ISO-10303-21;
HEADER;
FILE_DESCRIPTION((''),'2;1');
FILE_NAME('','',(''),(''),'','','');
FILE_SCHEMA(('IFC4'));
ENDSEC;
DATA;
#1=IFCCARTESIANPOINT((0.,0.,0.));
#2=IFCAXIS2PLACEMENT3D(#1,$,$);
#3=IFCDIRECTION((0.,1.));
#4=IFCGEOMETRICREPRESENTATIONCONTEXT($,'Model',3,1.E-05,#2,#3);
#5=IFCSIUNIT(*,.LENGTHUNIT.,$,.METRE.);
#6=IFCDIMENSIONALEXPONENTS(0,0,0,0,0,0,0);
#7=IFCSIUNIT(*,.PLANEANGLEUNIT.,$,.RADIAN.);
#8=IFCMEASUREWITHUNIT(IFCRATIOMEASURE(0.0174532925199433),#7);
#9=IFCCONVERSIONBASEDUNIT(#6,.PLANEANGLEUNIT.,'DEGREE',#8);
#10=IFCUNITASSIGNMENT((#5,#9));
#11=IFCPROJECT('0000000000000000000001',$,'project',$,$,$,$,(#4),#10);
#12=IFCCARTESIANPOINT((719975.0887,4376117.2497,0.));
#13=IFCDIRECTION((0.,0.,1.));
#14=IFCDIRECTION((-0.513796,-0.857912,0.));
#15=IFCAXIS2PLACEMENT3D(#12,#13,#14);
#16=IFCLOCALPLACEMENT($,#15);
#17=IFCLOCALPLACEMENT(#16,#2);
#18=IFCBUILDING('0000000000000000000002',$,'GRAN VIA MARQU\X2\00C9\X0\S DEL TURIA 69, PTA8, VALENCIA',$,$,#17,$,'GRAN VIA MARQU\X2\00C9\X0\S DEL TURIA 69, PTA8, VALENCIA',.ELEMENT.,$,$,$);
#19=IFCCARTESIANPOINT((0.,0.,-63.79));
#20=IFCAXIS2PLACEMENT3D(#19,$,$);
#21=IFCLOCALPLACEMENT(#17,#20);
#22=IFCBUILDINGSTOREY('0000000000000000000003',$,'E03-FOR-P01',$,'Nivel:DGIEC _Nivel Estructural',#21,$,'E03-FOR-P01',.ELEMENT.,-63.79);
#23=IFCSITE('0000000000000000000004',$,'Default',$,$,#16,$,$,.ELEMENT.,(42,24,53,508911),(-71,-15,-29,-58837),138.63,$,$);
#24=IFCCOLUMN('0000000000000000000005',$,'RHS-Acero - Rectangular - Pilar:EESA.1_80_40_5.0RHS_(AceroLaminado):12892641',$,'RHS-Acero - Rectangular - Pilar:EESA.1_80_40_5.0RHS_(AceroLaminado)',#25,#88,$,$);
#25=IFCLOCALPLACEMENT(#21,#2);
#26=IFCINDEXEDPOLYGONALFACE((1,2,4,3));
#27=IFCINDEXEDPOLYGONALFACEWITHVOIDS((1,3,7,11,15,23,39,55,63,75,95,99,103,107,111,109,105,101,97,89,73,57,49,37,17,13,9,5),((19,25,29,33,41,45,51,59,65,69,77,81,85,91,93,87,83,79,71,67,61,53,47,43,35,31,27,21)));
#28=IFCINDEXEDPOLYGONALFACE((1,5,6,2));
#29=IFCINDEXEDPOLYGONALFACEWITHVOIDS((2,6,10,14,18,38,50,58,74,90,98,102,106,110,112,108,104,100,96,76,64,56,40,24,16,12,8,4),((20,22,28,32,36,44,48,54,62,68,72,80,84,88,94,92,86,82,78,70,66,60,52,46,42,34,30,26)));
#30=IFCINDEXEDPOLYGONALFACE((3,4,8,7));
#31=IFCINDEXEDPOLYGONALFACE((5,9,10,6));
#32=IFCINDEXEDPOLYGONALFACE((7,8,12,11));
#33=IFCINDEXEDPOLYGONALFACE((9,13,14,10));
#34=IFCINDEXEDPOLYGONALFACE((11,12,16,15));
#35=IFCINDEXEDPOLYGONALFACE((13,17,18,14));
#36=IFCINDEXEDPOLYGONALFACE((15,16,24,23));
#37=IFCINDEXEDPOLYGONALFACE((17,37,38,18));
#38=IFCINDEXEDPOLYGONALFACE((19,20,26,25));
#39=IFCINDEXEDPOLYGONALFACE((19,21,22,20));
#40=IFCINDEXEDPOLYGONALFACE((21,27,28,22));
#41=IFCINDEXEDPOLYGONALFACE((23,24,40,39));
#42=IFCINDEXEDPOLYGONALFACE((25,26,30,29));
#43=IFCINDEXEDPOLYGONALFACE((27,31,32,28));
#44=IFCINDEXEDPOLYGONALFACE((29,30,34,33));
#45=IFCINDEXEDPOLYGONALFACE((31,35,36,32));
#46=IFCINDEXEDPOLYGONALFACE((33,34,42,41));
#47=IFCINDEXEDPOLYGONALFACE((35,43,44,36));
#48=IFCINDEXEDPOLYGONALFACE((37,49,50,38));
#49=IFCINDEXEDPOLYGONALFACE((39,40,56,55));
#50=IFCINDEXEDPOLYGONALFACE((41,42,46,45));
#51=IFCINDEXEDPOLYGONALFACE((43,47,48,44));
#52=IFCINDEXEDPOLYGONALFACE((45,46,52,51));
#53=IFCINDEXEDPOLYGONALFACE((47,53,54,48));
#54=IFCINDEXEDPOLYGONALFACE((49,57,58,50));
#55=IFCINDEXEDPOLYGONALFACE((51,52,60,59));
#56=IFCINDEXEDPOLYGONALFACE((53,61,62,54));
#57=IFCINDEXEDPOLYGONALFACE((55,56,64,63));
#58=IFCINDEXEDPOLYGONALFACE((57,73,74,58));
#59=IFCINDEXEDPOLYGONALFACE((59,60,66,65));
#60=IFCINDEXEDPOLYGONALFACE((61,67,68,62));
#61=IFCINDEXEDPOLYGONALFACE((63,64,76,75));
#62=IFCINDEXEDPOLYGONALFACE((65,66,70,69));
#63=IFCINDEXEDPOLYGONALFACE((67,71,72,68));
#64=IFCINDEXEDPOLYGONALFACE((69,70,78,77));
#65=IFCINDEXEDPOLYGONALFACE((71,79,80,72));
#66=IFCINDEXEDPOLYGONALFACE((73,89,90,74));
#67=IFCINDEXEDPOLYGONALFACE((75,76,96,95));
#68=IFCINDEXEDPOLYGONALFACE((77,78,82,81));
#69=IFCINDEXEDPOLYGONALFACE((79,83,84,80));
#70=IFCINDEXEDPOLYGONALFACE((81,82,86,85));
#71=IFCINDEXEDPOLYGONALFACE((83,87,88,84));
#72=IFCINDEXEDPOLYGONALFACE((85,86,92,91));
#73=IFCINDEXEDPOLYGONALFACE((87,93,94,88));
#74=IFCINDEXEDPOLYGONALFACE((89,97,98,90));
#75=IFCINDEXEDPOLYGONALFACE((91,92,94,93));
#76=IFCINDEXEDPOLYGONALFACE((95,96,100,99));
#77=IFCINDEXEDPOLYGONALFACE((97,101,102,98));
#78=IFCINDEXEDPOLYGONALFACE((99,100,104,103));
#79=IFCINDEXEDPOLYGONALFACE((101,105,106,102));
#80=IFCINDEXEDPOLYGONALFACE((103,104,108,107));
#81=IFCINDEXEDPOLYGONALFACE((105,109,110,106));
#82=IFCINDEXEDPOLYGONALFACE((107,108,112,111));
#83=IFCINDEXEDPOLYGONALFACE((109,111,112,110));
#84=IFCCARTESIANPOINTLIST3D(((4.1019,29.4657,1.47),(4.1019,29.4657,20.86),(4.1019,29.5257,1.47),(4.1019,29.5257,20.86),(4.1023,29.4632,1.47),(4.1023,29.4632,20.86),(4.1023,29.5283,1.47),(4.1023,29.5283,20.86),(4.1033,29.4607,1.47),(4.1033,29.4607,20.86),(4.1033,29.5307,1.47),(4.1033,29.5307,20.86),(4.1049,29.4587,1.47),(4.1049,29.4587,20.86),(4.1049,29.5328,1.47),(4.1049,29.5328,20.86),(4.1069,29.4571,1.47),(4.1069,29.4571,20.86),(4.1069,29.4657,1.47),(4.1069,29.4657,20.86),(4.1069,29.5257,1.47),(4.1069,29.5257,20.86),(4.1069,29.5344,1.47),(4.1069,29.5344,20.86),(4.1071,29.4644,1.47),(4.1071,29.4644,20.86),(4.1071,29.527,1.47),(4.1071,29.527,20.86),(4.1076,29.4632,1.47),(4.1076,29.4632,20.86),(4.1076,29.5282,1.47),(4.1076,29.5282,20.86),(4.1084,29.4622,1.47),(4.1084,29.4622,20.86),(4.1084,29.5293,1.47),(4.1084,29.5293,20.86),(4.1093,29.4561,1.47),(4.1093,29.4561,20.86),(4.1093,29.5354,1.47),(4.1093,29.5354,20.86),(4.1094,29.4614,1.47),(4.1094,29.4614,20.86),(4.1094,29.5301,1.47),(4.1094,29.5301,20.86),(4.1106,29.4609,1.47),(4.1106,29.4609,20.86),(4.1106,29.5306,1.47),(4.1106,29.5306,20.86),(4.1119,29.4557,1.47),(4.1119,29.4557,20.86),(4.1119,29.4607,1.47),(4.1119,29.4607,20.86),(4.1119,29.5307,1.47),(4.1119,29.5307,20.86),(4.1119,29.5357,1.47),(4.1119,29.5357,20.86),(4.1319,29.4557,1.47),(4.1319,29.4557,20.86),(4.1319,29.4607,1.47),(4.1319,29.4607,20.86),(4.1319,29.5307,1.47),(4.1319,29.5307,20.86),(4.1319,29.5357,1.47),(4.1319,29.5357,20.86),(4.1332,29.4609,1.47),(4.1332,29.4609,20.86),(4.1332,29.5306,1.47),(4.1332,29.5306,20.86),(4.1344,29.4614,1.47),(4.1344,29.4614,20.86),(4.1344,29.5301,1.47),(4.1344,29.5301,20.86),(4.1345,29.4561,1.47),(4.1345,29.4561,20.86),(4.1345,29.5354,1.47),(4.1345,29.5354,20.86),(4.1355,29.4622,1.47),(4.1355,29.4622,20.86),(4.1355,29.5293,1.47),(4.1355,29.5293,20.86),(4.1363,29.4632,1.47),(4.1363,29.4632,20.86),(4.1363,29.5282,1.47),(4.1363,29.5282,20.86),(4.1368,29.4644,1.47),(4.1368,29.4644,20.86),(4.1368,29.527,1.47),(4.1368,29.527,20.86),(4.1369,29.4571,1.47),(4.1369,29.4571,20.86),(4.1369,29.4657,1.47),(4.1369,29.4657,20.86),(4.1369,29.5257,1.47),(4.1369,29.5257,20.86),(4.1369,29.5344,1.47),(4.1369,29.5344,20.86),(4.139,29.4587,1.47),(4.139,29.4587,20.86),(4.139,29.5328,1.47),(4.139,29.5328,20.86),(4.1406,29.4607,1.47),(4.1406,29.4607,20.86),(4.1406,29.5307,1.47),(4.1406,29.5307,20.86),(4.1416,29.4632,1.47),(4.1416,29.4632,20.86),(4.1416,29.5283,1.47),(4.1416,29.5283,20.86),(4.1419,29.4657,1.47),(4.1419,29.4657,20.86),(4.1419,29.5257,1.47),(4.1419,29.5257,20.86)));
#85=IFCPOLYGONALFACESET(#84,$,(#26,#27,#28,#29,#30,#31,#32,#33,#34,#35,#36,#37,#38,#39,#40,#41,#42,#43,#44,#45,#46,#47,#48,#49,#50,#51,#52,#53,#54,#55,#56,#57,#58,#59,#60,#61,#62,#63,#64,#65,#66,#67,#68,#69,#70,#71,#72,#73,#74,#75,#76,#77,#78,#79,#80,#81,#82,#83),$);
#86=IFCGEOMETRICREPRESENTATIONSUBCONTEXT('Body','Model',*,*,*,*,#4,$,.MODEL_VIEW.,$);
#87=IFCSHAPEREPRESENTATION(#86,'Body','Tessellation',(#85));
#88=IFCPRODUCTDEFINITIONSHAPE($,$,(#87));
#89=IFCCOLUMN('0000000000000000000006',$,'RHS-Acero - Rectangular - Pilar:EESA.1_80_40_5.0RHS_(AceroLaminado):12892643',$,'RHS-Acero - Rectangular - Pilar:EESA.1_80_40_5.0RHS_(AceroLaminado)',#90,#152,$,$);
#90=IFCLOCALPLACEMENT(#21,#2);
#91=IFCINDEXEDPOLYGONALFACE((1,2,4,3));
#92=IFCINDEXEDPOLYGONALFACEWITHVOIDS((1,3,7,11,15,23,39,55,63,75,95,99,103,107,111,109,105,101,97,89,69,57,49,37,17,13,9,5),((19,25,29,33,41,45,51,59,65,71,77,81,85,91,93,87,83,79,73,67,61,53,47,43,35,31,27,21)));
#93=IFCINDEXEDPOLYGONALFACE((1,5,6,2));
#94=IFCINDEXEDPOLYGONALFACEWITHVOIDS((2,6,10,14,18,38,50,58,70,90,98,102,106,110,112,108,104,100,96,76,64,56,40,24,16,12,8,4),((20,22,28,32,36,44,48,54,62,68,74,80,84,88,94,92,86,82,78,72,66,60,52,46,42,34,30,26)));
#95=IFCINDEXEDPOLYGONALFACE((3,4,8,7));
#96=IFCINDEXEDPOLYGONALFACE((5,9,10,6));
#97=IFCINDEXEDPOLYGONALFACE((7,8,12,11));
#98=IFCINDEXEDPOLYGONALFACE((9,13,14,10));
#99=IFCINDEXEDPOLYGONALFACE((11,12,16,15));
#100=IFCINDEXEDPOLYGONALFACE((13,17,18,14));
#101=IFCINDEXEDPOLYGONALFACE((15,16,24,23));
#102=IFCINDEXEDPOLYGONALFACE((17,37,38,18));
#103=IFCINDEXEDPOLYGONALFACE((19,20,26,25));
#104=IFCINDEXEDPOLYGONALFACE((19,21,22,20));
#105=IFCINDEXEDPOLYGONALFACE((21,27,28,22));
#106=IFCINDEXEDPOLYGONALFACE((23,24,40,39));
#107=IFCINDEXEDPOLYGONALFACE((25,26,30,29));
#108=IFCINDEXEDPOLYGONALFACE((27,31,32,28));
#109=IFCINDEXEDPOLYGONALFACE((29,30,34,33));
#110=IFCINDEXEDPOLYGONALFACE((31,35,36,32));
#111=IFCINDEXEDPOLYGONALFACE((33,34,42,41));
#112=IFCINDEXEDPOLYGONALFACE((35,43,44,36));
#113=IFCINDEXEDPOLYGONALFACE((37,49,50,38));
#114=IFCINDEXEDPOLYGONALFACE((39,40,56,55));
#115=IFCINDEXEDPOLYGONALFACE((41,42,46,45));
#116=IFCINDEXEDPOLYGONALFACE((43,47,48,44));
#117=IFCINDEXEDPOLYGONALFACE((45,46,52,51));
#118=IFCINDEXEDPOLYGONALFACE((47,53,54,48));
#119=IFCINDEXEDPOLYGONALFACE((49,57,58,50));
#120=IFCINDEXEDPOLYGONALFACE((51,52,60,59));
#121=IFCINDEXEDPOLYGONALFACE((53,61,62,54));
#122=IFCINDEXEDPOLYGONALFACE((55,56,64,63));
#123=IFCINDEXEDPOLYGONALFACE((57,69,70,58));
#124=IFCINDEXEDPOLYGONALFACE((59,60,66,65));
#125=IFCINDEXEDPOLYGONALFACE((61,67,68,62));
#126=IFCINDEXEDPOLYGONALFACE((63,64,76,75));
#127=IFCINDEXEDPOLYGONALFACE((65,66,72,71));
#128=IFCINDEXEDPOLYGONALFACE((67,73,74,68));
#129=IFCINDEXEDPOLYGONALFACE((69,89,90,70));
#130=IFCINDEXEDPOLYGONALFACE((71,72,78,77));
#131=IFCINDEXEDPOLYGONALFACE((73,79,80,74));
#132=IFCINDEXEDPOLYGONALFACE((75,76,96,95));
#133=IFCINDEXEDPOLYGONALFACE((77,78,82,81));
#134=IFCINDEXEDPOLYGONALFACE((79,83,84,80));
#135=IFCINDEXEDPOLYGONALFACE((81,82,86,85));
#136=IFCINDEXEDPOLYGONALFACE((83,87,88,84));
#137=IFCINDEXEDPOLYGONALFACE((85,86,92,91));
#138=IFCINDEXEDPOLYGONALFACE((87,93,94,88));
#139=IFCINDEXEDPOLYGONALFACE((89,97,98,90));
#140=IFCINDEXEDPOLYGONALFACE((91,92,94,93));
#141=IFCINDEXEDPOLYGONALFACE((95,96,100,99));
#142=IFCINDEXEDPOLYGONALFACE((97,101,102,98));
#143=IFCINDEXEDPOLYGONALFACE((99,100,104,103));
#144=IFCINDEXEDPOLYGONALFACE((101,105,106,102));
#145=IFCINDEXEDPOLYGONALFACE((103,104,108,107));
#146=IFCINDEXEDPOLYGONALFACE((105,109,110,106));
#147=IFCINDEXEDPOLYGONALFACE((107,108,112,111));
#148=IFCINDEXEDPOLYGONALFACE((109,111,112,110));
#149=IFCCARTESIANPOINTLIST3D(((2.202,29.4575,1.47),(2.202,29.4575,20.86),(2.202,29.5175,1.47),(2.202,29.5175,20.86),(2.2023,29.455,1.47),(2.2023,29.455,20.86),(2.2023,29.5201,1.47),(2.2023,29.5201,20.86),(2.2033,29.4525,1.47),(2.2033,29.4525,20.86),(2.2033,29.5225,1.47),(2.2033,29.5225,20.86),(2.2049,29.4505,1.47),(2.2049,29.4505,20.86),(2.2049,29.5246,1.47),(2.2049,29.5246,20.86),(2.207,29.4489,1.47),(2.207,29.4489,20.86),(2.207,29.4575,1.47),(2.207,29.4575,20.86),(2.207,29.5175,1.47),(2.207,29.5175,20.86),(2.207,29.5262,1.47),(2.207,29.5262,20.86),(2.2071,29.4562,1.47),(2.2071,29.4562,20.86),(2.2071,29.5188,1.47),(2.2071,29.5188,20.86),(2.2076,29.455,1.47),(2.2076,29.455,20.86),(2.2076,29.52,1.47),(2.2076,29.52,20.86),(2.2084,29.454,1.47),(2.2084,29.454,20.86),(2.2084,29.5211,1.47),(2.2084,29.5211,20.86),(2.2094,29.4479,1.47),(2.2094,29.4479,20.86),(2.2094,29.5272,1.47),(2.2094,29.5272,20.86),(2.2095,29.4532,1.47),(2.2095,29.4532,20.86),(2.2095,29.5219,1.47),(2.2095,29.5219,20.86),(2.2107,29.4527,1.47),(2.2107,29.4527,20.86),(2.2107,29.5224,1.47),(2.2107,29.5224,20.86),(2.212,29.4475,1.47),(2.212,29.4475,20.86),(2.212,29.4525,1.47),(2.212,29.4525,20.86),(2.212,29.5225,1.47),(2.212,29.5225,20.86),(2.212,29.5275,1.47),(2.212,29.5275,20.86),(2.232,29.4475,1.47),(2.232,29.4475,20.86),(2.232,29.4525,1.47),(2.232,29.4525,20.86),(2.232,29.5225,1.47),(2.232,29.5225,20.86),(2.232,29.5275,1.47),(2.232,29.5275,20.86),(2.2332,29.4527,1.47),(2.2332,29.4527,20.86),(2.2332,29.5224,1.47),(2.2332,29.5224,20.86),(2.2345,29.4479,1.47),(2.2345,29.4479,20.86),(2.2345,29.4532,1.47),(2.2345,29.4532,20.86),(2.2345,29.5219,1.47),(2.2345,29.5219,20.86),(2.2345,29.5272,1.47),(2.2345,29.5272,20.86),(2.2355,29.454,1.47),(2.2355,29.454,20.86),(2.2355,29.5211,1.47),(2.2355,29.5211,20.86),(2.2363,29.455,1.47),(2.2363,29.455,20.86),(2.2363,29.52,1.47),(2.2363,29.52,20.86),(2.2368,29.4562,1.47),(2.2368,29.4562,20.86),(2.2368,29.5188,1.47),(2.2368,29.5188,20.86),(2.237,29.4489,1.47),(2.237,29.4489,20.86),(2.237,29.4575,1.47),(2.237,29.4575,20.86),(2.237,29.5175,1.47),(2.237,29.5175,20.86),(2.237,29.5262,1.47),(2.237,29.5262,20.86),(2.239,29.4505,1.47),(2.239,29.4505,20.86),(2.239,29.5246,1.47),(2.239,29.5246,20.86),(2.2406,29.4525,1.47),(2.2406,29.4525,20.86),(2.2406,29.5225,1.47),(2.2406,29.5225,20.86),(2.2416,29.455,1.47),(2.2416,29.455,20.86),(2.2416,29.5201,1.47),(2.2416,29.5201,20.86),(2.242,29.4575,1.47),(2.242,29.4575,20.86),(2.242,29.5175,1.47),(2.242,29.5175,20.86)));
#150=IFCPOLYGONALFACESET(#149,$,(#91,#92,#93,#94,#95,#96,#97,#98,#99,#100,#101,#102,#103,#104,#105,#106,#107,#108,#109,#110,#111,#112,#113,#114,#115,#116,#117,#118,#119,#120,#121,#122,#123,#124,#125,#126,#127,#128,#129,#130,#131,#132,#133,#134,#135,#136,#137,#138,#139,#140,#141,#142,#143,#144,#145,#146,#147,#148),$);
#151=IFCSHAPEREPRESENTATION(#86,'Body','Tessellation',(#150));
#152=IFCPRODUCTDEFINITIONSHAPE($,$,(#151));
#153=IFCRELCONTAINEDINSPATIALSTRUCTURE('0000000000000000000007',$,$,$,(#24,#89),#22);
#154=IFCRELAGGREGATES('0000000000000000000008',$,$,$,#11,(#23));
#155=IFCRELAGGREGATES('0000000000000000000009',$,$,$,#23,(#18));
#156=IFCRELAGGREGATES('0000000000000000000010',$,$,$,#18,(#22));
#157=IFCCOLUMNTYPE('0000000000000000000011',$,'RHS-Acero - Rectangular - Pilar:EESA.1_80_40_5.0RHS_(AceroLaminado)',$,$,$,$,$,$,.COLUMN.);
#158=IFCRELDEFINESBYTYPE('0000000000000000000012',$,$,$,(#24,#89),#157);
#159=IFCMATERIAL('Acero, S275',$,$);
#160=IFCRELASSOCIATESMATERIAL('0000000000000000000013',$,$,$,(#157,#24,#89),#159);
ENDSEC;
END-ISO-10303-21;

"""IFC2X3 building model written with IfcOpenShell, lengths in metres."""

from ifc_helpers import new_model, entity, si_unit, converted_unit, direction, frame, frame_2d, origin, place, context, subcontext, project, spatial, polyline, circle_curve, parameter, trimmed, segment, composite_curve, outline, extrude, source, transform, mapped, material, type_object, type_shapes, element, save


model = new_model("IFC2X3")

# Units and contexts
model_context = context("Model", 3, precision=1e-05, world=origin(), true_north=direction((0.0, 1.0)))
body_context = subcontext(model_context, "Body", "Model", "MODEL_VIEW")
ifc_project = project(units=[si_unit("LENGTHUNIT", "METRE"), converted_unit("PLANEANGLEUNIT", "DEGREE", entity("IfcRatioMeasure", 0.0174532925199433), si_unit("PLANEANGLEUNIT", "RADIAN"), dimensions=[0, 0, 0, 0, 0, 0, 0])], contexts=[model_context])

# Site, building, storey
site_placement = place(None, frame((719975.0887, 4376117.2497, 0.0), z_axis=(0.0, 0.0, 1.0), x_axis=(-0.513796, -0.857912, 0.0)))
site = spatial("IfcSite", under=ifc_project, at=site_placement, Name="Default", CompositionType="ELEMENT", RefLatitude=(42, 24, 53, 508911), RefLongitude=(-71, -15, -29, -58837), RefElevation=138.63)
building_placement = place(site_placement, origin())
building = spatial("IfcBuilding", under=site, at=building_placement, Name="GRAN VIA MARQUÉS DEL TURIA 69, PTA8, VALENCIA", LongName="GRAN VIA MARQUÉS DEL TURIA 69, PTA8, VALENCIA", CompositionType="ELEMENT")
storey_placement = place(building_placement, frame((0.0, 0.0, -63.79)))
storey = spatial("IfcBuildingStorey", under=building, at=storey_placement, Name="E03-FOR-P01", ObjectType="Nivel:DGIEC _Nivel Estructural", LongName="E03-FOR-P01", CompositionType="ELEMENT", Elevation=-63.79)

# Columns
ifc_material_1 = material(Name="Acero, S275")
column_type_1 = type_object("IfcColumnType", Name="RHS-Acero - Rectangular - Pilar:EESA.1_80_40_5.0RHS_(AceroLaminado)", PredefinedType="COLUMN", material=ifc_material_1)
shared_shape_1 = source(origin(), body_context, "Body", "SweptSolid", [
    extrude(outline(composite_curve([segment(polyline([(-0.01, -0.04), (0.01, -0.04)]), True, "CONTINUOUS"), segment(trimmed(circle_curve(frame_2d((0.01, -0.03), x_axis=(-1.0, 0.0)), 0.01), [parameter(90.0)], [parameter(180.0)], True, "PARAMETER"), True, "CONTINUOUS"), segment(polyline([(0.02, -0.03), (0.02, 0.03)]), True, "CONTINUOUS"), segment(trimmed(circle_curve(frame_2d((0.01, 0.03), x_axis=(-1.0, 0.0)), 0.01), [parameter(180.0)], [parameter(270.0)], True, "PARAMETER"), True, "CONTINUOUS"), segment(polyline([(0.01, 0.04), (-0.01, 0.04)]), True, "CONTINUOUS"), segment(trimmed(circle_curve(frame_2d((-0.01, 0.03), x_axis=(-1.0, 0.0)), 0.01), [parameter(270.0)], [parameter(360.0)], True, "PARAMETER"), True, "CONTINUOUS"), segment(polyline([(-0.02, 0.03), (-0.02, -0.03)]), True, "CONTINUOUS"), segment(trimmed(circle_curve(frame_2d((-0.01, -0.03), x_axis=(-1.0, 0.0)), 0.01), [parameter(360.0)], [parameter(90.0)], True, "PARAMETER"), True, "CONTINUOUS")], self_intersect=False), holes=[composite_curve([segment(trimmed(circle_curve(frame_2d((-0.01, -0.03), x_axis=(-1.0, 0.0)), 0.005), [parameter(0.0)], [parameter(90.0)], True, "PARAMETER"), False, "CONTINUOUS"), segment(polyline([(-0.015, -0.03), (-0.015, 0.03)]), True, "CONTINUOUS"), segment(trimmed(circle_curve(frame_2d((-0.01, 0.03), x_axis=(-1.0, 0.0)), 0.005), [parameter(270.0)], [parameter(0.0)], True, "PARAMETER"), False, "CONTINUOUS"), segment(polyline([(-0.01, 0.035), (0.01, 0.035)]), True, "CONTINUOUS"), segment(trimmed(circle_curve(frame_2d((0.01, 0.03), x_axis=(-1.0, 0.0)), 0.005), [parameter(180.0)], [parameter(270.0)], True, "PARAMETER"), False, "CONTINUOUS"), segment(polyline([(0.015, 0.03), (0.015, -0.03)]), True, "CONTINUOUS"), segment(trimmed(circle_curve(frame_2d((0.01, -0.03), x_axis=(-1.0, 0.0)), 0.005), [parameter(90.0)], [parameter(180.0)], True, "PARAMETER"), False, "CONTINUOUS"), segment(polyline([(0.01, -0.035), (-0.01, -0.035)]), True, "CONTINUOUS")], self_intersect=False)]), frame((0.0, 0.0, -62.32), z_axis=(0.0, 0.0, 1.0), x_axis=(-1.0, 0.0, 0.0)), (0.0, 0.0, 1.0), 19.39),
])
type_shapes(column_type_1, [shared_shape_1])
for number, where, z_axis, x_axis, name in (
    (1, (4.1219, 29.4957, 63.79), (0.0, 0.0, 1.0), (-1.0, 0.0, 0.0), "RHS-Acero - Rectangular - Pilar:EESA.1_80_40_5.0RHS_(AceroLaminado):12892641"),
    (2, (2.222, 29.4875, 63.79), (0.0, 0.0, 1.0), (-1.0, 0.0, 0.0), "RHS-Acero - Rectangular - Pilar:EESA.1_80_40_5.0RHS_(AceroLaminado):12892643"),
):
    element("IfcColumn", number, at=place(storey_placement, frame(where, z_axis=z_axis, x_axis=x_axis)), inside=storey, type_object=column_type_1, material=ifc_material_1, Name=name, ObjectType="RHS-Acero - Rectangular - Pilar:EESA.1_80_40_5.0RHS_(AceroLaminado)", context=body_context, shape_type="MappedRepresentation", body=[
        mapped(shared_shape_1, transform((0.0, 0.0, 0.0), scale=1.0)),
    ])

save(model, "model.ifc")
